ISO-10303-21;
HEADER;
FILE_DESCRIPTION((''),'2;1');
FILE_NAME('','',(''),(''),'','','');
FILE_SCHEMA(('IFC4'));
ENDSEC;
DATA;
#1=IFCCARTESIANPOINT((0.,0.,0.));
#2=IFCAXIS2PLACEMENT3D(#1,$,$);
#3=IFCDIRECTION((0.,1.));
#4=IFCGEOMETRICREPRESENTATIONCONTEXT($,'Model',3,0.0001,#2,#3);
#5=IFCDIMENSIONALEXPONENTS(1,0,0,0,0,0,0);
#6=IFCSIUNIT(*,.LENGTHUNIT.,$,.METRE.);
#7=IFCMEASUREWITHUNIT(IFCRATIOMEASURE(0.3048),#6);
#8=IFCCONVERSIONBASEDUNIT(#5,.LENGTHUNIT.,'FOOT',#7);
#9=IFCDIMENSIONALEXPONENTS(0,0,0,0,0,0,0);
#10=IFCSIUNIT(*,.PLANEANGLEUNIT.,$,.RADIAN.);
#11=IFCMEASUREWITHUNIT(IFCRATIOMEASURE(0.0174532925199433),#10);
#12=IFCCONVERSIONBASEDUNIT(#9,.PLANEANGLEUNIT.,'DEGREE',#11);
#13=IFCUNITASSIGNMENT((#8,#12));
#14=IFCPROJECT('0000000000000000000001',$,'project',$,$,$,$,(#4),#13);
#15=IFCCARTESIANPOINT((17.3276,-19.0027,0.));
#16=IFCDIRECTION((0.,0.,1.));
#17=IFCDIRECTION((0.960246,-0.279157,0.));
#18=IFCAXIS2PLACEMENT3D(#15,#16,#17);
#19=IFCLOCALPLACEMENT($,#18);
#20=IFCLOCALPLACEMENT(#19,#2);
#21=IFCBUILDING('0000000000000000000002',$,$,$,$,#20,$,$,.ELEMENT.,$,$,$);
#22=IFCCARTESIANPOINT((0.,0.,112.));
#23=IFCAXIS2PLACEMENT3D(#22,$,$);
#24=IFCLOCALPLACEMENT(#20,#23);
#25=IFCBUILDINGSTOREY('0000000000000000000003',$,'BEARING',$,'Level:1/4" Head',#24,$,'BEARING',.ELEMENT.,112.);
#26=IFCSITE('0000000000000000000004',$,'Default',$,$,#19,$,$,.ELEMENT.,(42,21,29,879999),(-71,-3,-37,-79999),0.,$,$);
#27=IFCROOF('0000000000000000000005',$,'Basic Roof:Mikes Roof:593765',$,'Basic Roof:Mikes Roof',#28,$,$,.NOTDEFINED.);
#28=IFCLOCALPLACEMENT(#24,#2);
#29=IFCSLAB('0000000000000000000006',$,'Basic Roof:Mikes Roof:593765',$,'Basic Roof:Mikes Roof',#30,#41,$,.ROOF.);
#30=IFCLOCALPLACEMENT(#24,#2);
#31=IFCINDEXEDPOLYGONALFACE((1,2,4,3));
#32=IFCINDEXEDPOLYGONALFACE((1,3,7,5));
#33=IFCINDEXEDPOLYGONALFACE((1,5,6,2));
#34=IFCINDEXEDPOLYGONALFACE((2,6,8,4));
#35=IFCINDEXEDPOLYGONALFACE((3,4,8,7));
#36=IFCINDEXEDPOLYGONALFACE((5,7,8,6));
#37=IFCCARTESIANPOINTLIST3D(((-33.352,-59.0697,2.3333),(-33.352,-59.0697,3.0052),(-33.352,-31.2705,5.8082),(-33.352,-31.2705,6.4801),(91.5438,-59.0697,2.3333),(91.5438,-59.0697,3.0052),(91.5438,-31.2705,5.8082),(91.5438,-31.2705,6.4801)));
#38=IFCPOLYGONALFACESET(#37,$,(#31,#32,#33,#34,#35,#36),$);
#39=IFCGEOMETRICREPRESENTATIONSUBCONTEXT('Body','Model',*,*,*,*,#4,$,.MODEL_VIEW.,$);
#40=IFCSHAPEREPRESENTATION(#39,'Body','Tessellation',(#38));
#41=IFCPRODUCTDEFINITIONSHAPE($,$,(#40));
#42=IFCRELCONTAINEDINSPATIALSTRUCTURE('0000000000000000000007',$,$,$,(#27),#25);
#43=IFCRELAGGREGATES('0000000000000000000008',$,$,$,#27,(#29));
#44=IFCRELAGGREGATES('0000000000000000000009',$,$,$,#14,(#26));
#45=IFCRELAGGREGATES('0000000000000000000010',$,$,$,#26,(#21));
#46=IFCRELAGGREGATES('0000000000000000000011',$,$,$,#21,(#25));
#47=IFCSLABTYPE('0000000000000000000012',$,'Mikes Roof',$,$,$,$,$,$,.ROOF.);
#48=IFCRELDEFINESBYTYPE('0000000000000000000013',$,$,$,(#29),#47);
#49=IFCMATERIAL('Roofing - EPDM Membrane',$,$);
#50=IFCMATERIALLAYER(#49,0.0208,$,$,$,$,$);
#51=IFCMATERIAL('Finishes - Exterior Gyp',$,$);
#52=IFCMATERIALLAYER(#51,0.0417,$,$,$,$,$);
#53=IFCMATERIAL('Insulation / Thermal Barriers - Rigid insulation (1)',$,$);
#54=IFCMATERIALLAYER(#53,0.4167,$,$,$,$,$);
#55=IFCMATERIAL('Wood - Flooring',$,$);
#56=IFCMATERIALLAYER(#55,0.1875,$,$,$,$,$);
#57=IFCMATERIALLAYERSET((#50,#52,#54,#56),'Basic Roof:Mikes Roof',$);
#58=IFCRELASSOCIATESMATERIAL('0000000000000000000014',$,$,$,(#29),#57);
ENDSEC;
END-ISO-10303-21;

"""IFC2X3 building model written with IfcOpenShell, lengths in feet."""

from ifc_helpers import new_model, entity, si_unit, converted_unit, direction, frame, frame_2d, origin, place, context, subcontext, project, spatial, rectangle, extrude, material, layer, layer_set, type_object, element, aggregate, save


model = new_model("IFC2X3")

# Units and contexts
model_context = context("Model", 3, precision=0.0001, world=origin(), true_north=direction((0.0, 1.0)))
body_context = subcontext(model_context, "Body", "Model", "MODEL_VIEW")
ifc_project = project(units=[converted_unit("LENGTHUNIT", "FOOT", entity("IfcRatioMeasure", 0.3048), si_unit("LENGTHUNIT", "METRE"), dimensions=[1, 0, 0, 0, 0, 0, 0]), converted_unit("PLANEANGLEUNIT", "DEGREE", entity("IfcRatioMeasure", 0.0174532925199433), si_unit("PLANEANGLEUNIT", "RADIAN"), dimensions=[0, 0, 0, 0, 0, 0, 0])], contexts=[model_context])

# Site, building, storey
site_placement = place(None, frame((17.3276, -19.0027, 0.0), z_axis=(0.0, 0.0, 1.0), x_axis=(0.960246, -0.279157, 0.0)))
site = spatial("IfcSite", under=ifc_project, at=site_placement, Name="Default", CompositionType="ELEMENT", RefLatitude=(42, 21, 29, 879999), RefLongitude=(-71, -3, -37, -79999), RefElevation=0.0)
building_placement = place(site_placement, origin())
building = spatial("IfcBuilding", under=site, at=building_placement, CompositionType="ELEMENT")
storey_placement = place(building_placement, frame((0.0, 0.0, 112.0)))
storey = spatial("IfcBuildingStorey", under=building, at=storey_placement, Name="BEARING", ObjectType="Level:1/4\" Head", LongName="BEARING", CompositionType="ELEMENT", Elevation=112.0)

# Roof, slab
roof_placement = place(storey_placement, frame((-33.352, -59.0697, 2.3333)))
roof = element("IfcRoof", 1, at=roof_placement, inside=storey, Name="Basic Roof:Mikes Roof:593765", ObjectType="Basic Roof:Mikes Roof", ShapeType="NOTDEFINED")
ifc_material_1 = material(Name="Roofing - EPDM Membrane")
ifc_layer_1 = layer(ifc_material_1, 0.0208)
ifc_material_2 = material(Name="Finishes - Exterior Gyp")
ifc_layer_2 = layer(ifc_material_2, 0.0417)
ifc_material_3 = material(Name="Insulation / Thermal Barriers - Rigid insulation (1)")
ifc_layer_3 = layer(ifc_material_3, 0.4167)
ifc_material_4 = material(Name="Wood - Flooring")
ifc_layer_4 = layer(ifc_material_4, 0.1875)
ifc_layer_set = layer_set([ifc_layer_1, ifc_layer_2, ifc_layer_3, ifc_layer_4], Name="Basic Roof:Mikes Roof")
slab_type = type_object("IfcSlabType", Name="Mikes Roof", PredefinedType="ROOF")
slab_placement = place(roof_placement, origin())
slab = element("IfcSlab", 2, at=slab_placement, type_object=slab_type, material=ifc_layer_set, Name="Basic Roof:Mikes Roof:593765", ObjectType="Basic Roof:Mikes Roof", PredefinedType="ROOF", context=body_context, shape_type="SweptSolid", body=[
    extrude(rectangle(XDim=124.8958, YDim=28.0155, at=frame_2d((0.0, 0.0), x_axis=(1.0, 0.0))), frame((62.4479, 13.8996, 1.7374), z_axis=(0.0, -0.124035, 0.992278), x_axis=(1.0, 0.0, 0.0)), (0.0, 0.124035, 0.992278), 0.6719),
])
aggregate(roof, [slab])

save(model, "model.ifc")
